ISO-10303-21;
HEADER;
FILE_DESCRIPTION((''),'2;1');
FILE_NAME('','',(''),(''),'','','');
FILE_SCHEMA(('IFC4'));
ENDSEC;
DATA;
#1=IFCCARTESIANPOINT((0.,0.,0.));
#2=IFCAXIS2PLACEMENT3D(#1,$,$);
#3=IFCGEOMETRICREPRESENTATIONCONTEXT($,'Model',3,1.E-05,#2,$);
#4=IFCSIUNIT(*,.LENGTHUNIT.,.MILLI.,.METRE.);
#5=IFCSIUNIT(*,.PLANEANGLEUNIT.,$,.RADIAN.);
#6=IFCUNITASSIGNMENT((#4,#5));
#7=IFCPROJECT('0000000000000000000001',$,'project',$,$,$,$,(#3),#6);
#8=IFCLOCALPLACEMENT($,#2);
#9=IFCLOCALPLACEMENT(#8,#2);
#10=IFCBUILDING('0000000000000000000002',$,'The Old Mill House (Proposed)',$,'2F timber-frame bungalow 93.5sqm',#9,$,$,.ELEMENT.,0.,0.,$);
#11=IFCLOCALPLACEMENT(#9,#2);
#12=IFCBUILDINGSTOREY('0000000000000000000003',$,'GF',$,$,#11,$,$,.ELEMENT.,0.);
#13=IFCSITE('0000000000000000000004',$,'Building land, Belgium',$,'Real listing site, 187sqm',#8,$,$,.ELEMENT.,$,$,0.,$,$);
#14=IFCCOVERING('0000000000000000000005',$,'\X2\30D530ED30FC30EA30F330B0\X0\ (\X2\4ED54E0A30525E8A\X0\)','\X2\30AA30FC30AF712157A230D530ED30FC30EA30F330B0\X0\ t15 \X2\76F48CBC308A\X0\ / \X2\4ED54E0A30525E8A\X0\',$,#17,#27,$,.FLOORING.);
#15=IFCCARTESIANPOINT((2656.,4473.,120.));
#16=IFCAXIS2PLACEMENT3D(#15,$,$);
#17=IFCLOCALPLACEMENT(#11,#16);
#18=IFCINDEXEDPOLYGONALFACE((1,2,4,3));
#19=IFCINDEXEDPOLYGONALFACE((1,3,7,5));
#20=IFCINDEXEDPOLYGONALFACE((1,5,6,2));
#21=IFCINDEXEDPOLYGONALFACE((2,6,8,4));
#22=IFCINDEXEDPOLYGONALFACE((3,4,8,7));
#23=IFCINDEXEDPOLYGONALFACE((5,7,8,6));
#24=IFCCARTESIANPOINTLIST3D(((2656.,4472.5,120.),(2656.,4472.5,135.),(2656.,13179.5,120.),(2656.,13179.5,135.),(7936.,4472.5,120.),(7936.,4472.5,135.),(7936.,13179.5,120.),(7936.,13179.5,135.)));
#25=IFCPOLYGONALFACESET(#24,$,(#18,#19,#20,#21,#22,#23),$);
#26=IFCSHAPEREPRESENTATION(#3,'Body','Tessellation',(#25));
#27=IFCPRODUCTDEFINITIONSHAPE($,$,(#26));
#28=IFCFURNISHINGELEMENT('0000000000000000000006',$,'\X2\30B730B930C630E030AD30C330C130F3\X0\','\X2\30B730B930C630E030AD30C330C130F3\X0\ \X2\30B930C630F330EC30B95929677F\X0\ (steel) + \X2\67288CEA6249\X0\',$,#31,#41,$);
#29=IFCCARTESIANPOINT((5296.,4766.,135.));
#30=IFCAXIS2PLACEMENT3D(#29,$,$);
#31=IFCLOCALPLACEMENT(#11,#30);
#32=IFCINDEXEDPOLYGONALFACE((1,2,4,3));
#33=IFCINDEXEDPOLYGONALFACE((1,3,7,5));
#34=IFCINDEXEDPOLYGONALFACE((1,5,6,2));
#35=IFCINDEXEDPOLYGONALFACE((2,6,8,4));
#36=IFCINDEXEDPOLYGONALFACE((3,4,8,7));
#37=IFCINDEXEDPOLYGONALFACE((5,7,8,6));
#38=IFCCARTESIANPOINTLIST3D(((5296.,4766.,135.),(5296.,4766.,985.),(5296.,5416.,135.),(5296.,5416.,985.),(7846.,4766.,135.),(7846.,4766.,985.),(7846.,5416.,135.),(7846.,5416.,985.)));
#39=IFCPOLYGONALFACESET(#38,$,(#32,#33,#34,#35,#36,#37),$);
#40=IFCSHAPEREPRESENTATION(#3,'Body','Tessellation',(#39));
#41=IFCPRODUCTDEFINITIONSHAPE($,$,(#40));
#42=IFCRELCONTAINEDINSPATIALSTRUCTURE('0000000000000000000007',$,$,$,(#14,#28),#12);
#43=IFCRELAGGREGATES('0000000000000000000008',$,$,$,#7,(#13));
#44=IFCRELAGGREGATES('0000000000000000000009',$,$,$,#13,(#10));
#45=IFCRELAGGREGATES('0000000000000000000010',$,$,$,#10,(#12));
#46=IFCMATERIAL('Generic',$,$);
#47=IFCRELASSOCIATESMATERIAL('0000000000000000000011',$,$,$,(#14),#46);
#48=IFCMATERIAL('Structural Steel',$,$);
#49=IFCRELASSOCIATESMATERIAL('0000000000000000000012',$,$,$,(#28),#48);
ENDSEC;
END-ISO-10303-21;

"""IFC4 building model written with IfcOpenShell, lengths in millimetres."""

from ifc_helpers import new_model, si_unit, frame, frame_2d, origin, place, context, project, spatial, rectangle, extrude, material, element, save


model = new_model("IFC4")

# Units and contexts
model_context = context("Model", 3, precision=1e-05, world=origin())
ifc_project = project(units=[si_unit("LENGTHUNIT", "METRE", prefix="MILLI"), si_unit("PLANEANGLEUNIT", "RADIAN")], contexts=[model_context])

# Site, building, storey
site_placement = place(None, origin())
site = spatial("IfcSite", under=ifc_project, at=site_placement, Name="Building land, Belgium", ObjectType="Real listing site, 187sqm", CompositionType="ELEMENT", RefElevation=0.0)
building_placement = place(site_placement, origin())
building = spatial("IfcBuilding", under=site, at=building_placement, Name="The Old Mill House (Proposed)", ObjectType="2F timber-frame bungalow 93.5sqm", CompositionType="ELEMENT", ElevationOfRefHeight=0.0, ElevationOfTerrain=0.0)
storey_placement = place(building_placement, origin())
storey = spatial("IfcBuildingStorey", under=building, at=storey_placement, Name="GF", CompositionType="ELEMENT", Elevation=0.0)

# Covering
ifc_material_1 = material(Name="Generic")
covering_placement = place(storey_placement, frame((2656.0, 4473.0, 120.0)))
element("IfcCovering", 1, at=covering_placement, inside=storey, material=ifc_material_1, Name="フローリング (仕上げ床)", Description="オーク無垢フローリング t15 直貼り / 仕上げ床", PredefinedType="FLOORING", context=model_context, shape_type="SweptSolid", body=[
    extrude(rectangle(XDim=5280.0, YDim=8707.0, at=frame_2d((2640.0, 4353.0))), frame((2656.0, 4473.0, 120.0)), (0.0, 0.0, 1.0), 15.0),
])

# Furnishing element
ifc_material_2 = material(Name="Structural Steel")
furnishing_placement = place(storey_placement, frame((5296.0, 4766.0, 135.0)))
element("IfcFurnishingElement", 2, at=furnishing_placement, inside=storey, material=ifc_material_2, Name="システムキッチン", Description="システムキッチン ステンレス天板 (steel) + 木質扉", context=model_context, shape_type="SweptSolid", body=[
    extrude(rectangle(XDim=2550.0, YDim=650.0, at=frame_2d((1275.0, 325.0))), frame((5296.0, 4766.0, 135.0)), (0.0, 0.0, 1.0), 850.0),
])

save(model, "model.ifc")
